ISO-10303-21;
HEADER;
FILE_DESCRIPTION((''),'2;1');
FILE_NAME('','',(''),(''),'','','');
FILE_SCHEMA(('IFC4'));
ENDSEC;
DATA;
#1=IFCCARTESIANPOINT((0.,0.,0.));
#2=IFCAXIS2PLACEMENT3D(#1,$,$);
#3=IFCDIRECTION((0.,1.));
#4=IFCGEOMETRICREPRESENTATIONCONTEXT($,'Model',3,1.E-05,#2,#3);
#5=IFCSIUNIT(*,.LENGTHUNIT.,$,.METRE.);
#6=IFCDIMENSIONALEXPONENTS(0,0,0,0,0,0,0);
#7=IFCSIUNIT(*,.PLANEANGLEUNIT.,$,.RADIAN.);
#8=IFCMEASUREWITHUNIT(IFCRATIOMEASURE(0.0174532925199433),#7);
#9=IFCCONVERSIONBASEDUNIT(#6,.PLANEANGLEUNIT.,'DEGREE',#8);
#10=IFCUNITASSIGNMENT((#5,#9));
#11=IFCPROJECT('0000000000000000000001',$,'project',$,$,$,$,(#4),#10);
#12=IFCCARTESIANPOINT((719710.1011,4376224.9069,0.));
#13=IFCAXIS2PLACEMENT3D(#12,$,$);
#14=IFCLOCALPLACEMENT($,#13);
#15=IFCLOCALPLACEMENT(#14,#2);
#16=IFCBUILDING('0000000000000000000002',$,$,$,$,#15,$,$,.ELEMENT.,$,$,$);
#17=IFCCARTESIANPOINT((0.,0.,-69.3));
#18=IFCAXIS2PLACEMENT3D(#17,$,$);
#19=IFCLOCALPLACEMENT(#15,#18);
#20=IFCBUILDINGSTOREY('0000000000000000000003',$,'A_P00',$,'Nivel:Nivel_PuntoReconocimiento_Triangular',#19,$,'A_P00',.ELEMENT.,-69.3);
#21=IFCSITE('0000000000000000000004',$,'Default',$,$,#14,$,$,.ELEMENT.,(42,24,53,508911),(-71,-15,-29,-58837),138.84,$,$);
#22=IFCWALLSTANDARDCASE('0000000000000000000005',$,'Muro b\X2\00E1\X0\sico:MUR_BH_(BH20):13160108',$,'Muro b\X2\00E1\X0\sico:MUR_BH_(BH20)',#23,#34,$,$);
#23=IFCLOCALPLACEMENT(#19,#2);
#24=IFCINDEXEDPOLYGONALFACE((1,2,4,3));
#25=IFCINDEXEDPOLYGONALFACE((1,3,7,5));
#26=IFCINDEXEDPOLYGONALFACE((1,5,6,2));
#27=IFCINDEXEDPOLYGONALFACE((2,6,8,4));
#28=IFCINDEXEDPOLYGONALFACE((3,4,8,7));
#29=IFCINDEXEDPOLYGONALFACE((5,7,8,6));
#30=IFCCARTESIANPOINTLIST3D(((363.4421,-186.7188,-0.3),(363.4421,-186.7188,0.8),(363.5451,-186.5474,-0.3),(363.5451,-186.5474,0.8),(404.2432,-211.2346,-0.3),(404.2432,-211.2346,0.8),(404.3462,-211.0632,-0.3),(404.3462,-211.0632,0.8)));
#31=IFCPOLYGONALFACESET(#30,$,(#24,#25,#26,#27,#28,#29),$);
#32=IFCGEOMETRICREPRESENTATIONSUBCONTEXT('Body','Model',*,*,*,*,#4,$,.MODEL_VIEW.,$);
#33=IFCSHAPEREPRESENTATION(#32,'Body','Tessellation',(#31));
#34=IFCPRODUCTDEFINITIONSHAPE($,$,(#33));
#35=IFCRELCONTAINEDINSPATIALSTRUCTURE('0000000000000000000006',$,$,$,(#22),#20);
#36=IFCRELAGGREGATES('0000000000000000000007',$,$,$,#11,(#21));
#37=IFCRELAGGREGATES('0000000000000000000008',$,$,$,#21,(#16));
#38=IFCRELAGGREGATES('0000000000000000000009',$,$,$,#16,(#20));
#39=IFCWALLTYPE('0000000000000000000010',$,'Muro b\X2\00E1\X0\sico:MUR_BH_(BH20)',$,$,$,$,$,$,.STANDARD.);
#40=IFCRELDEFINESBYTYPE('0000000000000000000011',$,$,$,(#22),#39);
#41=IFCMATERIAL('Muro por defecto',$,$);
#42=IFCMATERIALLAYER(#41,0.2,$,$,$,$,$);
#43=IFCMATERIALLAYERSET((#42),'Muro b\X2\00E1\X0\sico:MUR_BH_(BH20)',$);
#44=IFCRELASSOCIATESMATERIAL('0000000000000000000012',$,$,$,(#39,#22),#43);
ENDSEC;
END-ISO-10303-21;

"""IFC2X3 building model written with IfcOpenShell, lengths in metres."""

from ifc_helpers import new_model, entity, si_unit, converted_unit, direction, frame, frame_2d, origin, place, context, subcontext, project, spatial, rectangle, extrude, material, layer, layer_set, layer_usage, type_object, element, save


model = new_model("IFC2X3")

# Units and contexts
model_context = context("Model", 3, precision=1e-05, world=origin(), true_north=direction((0.0, 1.0)))
body_context = subcontext(model_context, "Body", "Model", "MODEL_VIEW")
ifc_project = project(units=[si_unit("LENGTHUNIT", "METRE"), converted_unit("PLANEANGLEUNIT", "DEGREE", entity("IfcRatioMeasure", 0.0174532925199433), si_unit("PLANEANGLEUNIT", "RADIAN"), dimensions=[0, 0, 0, 0, 0, 0, 0])], contexts=[model_context])

# Site, building, storey
site_placement = place(None, frame((719710.1011, 4376224.9069, 0.0)))
site = spatial("IfcSite", under=ifc_project, at=site_placement, Name="Default", CompositionType="ELEMENT", RefLatitude=(42, 24, 53, 508911), RefLongitude=(-71, -15, -29, -58837), RefElevation=138.84)
building_placement = place(site_placement, origin())
building = spatial("IfcBuilding", under=site, at=building_placement, CompositionType="ELEMENT")
storey_placement = place(building_placement, frame((0.0, 0.0, -69.3)))
storey = spatial("IfcBuildingStorey", under=building, at=storey_placement, Name="A_P00", ObjectType="Nivel:Nivel_PuntoReconocimiento_Triangular", LongName="A_P00", CompositionType="ELEMENT", Elevation=-69.3)

# Shared definitions
ifc_material_1 = material(Name="Muro por defecto")
ifc_layer = layer(ifc_material_1, 0.2)
ifc_layer_set = layer_set([ifc_layer], Name="Muro básico:MUR_BH_(BH20)")
wall_type = type_object("IfcWallType", Name="Muro básico:MUR_BH_(BH20)", PredefinedType="STANDARD", material=ifc_layer_set)

# Wall
ifc_layer_usage_1 = layer_usage(ifc_layer_set, "AXIS2", "NEGATIVE", 0.1)
wall_1_placement = place(storey_placement, frame((363.4936, -186.6331, -0.3), z_axis=(0.0, 0.0, 1.0), x_axis=(0.857167, -0.515038, 0.0)))
element("IfcWallStandardCase", 1, at=wall_1_placement, inside=storey, type_object=wall_type, material=ifc_layer_usage_1, Name="Muro básico:MUR_BH_(BH20):13160108", ObjectType="Muro básico:MUR_BH_(BH20)", context=body_context, shape_type="SweptSolid", body=[
    extrude(rectangle(XDim=47.6, YDim=0.2, at=frame_2d((23.8, 0.0), x_axis=(-1.0, 0.0))), origin(), (0.0, 0.0, 1.0), 1.1),
])

save(model, "model.ifc")
